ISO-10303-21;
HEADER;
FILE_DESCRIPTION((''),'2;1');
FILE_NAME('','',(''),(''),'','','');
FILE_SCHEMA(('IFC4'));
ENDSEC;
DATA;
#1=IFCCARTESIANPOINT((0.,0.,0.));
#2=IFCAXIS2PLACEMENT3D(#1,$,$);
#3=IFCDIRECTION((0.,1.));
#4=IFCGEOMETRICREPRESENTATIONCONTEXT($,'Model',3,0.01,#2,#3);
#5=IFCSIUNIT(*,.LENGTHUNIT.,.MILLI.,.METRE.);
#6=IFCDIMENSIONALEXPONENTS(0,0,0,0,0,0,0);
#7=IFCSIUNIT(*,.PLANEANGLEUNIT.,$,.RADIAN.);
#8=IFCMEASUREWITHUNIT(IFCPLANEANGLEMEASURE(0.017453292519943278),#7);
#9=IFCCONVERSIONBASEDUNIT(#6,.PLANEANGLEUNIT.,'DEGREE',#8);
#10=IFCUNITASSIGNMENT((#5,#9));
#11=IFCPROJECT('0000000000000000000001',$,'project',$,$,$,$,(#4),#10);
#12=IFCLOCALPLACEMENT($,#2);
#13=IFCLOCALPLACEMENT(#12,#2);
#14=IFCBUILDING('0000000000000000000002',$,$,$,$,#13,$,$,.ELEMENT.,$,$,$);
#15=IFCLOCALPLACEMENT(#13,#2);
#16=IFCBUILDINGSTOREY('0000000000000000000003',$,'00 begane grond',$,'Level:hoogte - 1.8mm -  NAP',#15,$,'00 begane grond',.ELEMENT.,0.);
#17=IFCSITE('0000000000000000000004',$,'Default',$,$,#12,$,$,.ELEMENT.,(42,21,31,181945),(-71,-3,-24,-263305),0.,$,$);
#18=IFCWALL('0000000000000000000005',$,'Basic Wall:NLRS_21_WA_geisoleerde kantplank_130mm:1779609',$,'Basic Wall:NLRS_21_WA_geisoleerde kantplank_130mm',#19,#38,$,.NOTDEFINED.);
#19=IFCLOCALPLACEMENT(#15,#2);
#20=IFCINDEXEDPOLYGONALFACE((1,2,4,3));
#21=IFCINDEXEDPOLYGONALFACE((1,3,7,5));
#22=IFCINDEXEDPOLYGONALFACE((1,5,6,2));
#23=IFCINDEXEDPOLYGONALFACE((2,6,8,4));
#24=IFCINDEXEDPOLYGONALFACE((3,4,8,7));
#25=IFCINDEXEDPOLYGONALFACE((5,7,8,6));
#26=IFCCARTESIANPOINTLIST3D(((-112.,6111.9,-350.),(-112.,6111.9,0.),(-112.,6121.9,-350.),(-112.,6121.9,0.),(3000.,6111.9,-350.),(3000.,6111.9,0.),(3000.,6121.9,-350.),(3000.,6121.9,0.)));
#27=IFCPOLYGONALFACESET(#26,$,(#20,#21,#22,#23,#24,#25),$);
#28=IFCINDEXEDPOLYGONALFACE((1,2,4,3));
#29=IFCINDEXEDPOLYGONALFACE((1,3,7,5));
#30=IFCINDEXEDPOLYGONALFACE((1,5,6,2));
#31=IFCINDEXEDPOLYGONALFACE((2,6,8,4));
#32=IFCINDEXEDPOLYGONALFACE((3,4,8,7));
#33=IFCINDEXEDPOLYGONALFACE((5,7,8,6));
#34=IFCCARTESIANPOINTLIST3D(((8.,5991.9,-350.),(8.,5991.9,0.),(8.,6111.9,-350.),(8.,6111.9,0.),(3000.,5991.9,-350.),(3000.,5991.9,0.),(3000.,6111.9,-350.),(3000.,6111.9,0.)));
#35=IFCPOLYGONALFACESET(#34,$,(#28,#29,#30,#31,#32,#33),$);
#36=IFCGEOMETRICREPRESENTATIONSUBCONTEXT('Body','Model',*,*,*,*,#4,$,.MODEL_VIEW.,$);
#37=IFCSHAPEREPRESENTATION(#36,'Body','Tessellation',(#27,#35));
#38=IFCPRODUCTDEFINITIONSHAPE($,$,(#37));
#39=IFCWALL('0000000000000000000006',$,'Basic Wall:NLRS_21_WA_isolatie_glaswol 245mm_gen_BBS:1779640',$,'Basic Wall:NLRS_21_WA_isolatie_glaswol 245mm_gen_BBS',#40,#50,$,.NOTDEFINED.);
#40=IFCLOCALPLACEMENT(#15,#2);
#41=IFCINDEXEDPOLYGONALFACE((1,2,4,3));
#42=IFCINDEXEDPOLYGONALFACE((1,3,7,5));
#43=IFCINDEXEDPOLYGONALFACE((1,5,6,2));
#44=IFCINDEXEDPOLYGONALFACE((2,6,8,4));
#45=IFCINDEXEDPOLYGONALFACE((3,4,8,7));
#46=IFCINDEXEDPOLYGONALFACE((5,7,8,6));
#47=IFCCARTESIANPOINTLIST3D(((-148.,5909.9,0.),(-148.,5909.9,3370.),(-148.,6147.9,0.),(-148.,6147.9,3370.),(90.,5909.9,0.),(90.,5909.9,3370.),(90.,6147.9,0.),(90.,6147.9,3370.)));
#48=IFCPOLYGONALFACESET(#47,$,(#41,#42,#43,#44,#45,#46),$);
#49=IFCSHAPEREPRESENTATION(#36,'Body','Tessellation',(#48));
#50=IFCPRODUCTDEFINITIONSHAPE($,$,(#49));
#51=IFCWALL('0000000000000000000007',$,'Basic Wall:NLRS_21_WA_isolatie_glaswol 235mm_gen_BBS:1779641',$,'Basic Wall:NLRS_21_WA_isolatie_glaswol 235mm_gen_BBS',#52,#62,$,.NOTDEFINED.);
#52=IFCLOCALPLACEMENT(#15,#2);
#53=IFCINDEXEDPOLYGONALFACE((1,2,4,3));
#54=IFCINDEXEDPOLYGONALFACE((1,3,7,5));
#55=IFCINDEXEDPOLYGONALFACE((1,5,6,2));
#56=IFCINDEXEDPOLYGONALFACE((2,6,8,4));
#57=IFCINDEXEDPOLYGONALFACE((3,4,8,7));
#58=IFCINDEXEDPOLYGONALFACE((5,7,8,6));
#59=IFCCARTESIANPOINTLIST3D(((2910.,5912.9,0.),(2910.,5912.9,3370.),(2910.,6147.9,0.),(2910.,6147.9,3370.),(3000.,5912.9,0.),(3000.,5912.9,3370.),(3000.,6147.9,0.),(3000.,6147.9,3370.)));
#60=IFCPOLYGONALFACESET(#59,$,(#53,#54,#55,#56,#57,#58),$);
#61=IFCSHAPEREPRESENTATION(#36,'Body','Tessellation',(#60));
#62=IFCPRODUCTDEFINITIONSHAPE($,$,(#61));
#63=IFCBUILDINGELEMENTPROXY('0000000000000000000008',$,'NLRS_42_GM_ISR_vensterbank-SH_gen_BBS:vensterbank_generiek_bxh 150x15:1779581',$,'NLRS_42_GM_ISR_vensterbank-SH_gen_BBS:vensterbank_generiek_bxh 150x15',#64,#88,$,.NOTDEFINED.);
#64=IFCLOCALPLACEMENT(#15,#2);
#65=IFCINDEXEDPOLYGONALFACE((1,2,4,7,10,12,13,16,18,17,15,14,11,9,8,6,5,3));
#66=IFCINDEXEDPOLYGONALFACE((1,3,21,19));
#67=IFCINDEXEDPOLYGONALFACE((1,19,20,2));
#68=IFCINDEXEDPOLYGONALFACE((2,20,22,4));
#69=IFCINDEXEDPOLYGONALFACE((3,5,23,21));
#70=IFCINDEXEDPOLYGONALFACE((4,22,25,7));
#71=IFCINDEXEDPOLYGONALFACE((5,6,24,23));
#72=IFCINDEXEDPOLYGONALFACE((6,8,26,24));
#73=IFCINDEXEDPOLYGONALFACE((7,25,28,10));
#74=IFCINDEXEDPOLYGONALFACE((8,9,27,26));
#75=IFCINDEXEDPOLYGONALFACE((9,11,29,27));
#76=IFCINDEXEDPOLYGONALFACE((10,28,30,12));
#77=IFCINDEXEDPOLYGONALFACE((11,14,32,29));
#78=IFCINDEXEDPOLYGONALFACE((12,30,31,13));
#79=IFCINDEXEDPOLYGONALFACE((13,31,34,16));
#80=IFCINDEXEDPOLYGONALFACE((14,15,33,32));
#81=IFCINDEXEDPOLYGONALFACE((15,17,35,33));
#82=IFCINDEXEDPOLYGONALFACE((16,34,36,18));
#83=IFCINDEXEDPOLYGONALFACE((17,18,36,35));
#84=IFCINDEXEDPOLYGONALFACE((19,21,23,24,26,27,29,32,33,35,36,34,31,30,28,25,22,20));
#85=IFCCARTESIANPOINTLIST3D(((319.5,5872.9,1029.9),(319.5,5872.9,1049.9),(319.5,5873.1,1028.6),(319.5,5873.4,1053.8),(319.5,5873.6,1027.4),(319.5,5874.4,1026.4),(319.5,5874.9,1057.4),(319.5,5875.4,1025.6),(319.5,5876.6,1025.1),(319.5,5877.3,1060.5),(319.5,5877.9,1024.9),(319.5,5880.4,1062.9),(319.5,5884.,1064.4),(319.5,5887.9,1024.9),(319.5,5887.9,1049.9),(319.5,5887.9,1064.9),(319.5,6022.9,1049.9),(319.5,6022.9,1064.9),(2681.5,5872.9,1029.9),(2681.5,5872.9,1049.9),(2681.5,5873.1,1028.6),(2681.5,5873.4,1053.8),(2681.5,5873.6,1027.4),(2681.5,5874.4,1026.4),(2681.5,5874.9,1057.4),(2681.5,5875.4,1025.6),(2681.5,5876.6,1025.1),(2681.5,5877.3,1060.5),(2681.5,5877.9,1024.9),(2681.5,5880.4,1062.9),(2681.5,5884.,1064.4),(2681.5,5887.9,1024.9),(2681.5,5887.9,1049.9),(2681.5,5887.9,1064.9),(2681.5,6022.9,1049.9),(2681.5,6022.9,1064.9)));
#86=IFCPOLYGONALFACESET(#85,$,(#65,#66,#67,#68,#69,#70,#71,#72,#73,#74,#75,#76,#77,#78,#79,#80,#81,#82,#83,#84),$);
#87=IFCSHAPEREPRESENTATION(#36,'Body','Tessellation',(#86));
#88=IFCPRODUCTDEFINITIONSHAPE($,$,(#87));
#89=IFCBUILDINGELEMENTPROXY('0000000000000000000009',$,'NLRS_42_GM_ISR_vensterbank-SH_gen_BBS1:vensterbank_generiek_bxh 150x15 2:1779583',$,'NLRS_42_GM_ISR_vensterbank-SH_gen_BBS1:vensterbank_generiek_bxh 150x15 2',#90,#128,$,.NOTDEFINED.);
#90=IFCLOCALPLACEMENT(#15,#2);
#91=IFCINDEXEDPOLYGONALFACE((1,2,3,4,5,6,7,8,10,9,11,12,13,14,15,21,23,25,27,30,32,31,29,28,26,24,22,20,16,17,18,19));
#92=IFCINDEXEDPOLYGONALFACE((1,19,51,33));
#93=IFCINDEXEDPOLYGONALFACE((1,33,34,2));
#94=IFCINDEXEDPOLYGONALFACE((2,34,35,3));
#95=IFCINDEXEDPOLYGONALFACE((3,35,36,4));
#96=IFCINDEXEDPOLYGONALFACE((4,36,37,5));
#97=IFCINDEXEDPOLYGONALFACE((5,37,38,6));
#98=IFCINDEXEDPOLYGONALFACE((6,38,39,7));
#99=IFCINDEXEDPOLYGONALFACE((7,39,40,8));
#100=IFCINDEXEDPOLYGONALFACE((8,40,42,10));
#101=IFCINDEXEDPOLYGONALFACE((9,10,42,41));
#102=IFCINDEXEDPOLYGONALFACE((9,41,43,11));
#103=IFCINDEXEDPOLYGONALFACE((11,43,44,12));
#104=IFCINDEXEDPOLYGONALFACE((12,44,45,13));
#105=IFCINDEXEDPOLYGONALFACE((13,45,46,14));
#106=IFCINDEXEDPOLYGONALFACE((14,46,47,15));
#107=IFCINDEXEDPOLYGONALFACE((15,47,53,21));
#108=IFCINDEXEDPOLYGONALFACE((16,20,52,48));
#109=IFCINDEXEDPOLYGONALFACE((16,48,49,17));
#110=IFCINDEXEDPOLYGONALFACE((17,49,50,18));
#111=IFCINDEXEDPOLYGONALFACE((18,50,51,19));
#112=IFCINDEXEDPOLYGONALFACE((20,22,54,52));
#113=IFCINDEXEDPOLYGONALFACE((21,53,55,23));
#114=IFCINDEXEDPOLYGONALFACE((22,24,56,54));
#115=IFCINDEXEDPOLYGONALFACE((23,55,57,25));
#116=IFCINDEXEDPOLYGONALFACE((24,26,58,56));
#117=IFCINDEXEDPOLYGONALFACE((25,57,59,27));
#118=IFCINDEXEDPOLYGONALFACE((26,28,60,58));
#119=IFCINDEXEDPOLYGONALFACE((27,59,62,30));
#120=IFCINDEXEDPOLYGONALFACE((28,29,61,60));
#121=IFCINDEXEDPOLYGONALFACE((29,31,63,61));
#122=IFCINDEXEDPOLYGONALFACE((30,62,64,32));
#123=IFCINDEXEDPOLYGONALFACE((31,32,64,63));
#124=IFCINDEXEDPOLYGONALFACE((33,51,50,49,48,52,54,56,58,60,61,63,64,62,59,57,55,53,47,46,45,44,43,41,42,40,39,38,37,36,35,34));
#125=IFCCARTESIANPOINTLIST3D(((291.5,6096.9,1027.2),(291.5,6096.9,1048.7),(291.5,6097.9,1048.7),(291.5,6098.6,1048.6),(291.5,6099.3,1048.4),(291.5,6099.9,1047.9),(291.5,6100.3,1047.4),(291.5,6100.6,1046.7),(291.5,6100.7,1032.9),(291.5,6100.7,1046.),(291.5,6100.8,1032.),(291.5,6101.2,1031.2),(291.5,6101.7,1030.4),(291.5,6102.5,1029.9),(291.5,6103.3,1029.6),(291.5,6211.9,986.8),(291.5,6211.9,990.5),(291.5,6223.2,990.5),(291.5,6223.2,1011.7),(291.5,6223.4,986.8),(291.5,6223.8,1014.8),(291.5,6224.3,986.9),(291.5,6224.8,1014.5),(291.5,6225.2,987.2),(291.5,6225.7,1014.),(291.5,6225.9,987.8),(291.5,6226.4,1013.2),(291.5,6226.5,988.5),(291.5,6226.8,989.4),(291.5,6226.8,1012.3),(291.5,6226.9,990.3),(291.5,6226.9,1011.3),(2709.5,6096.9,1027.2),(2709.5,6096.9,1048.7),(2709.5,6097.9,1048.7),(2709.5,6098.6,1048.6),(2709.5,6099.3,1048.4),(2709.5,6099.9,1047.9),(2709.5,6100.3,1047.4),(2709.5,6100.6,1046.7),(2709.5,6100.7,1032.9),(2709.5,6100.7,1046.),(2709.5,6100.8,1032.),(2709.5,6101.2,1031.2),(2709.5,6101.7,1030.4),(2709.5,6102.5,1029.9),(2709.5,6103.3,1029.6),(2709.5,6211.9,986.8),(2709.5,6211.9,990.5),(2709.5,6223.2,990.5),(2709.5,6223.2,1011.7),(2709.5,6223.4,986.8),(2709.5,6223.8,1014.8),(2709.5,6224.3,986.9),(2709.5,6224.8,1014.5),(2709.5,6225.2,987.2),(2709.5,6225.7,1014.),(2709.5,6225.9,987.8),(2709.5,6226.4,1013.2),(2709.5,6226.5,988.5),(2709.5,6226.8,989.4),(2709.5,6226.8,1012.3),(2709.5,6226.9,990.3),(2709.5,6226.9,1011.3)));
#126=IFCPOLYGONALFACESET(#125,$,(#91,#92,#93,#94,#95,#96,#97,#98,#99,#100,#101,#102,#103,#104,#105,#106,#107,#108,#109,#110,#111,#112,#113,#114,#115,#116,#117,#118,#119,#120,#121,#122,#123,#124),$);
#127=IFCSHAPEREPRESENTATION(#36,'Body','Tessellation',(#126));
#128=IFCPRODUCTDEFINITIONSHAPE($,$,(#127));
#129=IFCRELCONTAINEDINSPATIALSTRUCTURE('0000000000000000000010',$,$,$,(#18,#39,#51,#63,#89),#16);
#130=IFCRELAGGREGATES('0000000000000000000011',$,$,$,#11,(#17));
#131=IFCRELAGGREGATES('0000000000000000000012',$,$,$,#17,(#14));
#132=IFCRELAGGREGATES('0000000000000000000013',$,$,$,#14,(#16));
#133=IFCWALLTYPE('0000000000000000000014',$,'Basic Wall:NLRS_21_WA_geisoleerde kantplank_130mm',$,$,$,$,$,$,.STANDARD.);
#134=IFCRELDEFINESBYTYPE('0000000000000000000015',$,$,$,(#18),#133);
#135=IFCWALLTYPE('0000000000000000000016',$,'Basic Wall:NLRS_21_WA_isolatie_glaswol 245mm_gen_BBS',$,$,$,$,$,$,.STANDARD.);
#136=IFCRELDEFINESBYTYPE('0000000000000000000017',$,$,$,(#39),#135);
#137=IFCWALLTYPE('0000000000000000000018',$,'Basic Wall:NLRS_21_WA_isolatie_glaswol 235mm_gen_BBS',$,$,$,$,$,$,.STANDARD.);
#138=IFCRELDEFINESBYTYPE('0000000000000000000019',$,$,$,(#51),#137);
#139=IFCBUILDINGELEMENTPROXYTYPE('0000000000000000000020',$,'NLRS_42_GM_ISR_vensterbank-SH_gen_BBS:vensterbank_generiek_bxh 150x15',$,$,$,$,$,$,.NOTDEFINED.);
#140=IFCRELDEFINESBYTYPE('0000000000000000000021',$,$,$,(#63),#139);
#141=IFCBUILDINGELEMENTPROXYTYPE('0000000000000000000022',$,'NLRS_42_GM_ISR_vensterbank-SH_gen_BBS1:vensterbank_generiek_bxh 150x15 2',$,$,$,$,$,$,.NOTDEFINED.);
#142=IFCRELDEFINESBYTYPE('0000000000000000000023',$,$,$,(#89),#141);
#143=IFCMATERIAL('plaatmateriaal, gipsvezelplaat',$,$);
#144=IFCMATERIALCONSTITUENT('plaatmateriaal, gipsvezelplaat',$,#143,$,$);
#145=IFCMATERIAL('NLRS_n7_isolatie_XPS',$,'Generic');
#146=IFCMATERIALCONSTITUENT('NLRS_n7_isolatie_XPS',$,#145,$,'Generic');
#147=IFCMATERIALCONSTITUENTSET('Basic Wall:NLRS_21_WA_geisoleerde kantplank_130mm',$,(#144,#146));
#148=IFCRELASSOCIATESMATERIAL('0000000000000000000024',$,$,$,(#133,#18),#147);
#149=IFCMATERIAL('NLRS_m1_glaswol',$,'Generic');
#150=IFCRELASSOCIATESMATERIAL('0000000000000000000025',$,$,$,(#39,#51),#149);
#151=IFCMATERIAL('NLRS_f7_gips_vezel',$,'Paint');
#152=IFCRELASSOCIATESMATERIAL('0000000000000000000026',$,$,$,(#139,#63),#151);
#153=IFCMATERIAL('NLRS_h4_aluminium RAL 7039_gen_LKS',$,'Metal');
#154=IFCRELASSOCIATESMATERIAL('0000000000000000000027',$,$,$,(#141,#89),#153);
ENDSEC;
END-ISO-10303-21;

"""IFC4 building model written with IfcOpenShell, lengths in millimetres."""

from ifc_helpers import new_model, entity, si_unit, converted_unit, direction, frame, origin, place, context, subcontext, project, spatial, line, arc, indexed_curve, outline, extrude, source, transform, mapped, material, constituent, constituent_set, type_object, type_shapes, element, save


model = new_model("IFC4")

# Units and contexts
model_context = context("Model", 3, precision=0.01, world=origin(), true_north=direction((0.0, 1.0)))
body_context = subcontext(model_context, "Body", "Model", "MODEL_VIEW")
ifc_project = project(units=[si_unit("LENGTHUNIT", "METRE", prefix="MILLI"), converted_unit("PLANEANGLEUNIT", "DEGREE", entity("IfcPlaneAngleMeasure", 0.017453292519943278), si_unit("PLANEANGLEUNIT", "RADIAN"), dimensions=[0, 0, 0, 0, 0, 0, 0])], contexts=[model_context])

# Site, building, storey
site_placement = place(None, origin())
site = spatial("IfcSite", under=ifc_project, at=site_placement, Name="Default", CompositionType="ELEMENT", RefLatitude=(42, 21, 31, 181945), RefLongitude=(-71, -3, -24, -263305), RefElevation=0.0)
building_placement = place(site_placement, origin())
building = spatial("IfcBuilding", under=site, at=building_placement, CompositionType="ELEMENT")
storey_placement = place(building_placement, origin())
storey = spatial("IfcBuildingStorey", under=building, at=storey_placement, Name="00 begane grond", ObjectType="Level:hoogte - 1.8mm -  NAP", LongName="00 begane grond", CompositionType="ELEMENT", Elevation=0.0)

# Shared definitions
ifc_material_1 = material(Name="NLRS_f7_gips_vezel", Category="Paint")

# Shared definitions
ifc_material_2 = material(Name="NLRS_h4_aluminium RAL 7039_gen_LKS", Category="Metal")

# Walls
ifc_material_3 = material(Name="plaatmateriaal, gipsvezelplaat")
ifc_constituent_1 = constituent(ifc_material_3, Name="plaatmateriaal, gipsvezelplaat")
ifc_material_4 = material(Name="NLRS_n7_isolatie_XPS", Category="Generic")
ifc_constituent_2 = constituent(ifc_material_4, Name="NLRS_n7_isolatie_XPS", Category="Generic")
ifc_constituent_set_1 = constituent_set(constituents=[ifc_constituent_1, ifc_constituent_2], Name="Basic Wall:NLRS_21_WA_geisoleerde kantplank_130mm")
wall_type_1 = type_object("IfcWallType", Name="Basic Wall:NLRS_21_WA_geisoleerde kantplank_130mm", PredefinedType="STANDARD", material=ifc_constituent_set_1)
wall_1_placement = place(storey_placement, frame((8.0, 6056.9, -350.0)))
element("IfcWall", 1, at=wall_1_placement, inside=storey, type_object=wall_type_1, material=ifc_constituent_set_1, Name="Basic Wall:NLRS_21_WA_geisoleerde kantplank_130mm:1779609", ObjectType="Basic Wall:NLRS_21_WA_geisoleerde kantplank_130mm", PredefinedType="NOTDEFINED", context=body_context, shape_type="SweptSolid", body=[
    extrude(outline(indexed_curve([(-5.0, -1556.0), (5.0, -1556.0), (5.0, 1556.0), (-5.0, 1556.0), (-5.0, -1556.0)], self_intersect=False)), frame((1436.0, 60.0, 0.0), z_axis=(0.0, 0.0, 1.0), x_axis=(0.0, -1.0, 0.0)), (0.0, 0.0, 1.0), 350.0),
    extrude(outline(indexed_curve([(-60.0, -1496.0), (60.0, -1496.0), (60.0, 1496.0), (-60.0, 1496.0), (-60.0, -1496.0)], self_intersect=False)), frame((1496.0, -5.0, 0.0), z_axis=(0.0, 0.0, 1.0), x_axis=(0.0, 1.0, 0.0)), (0.0, 0.0, 1.0), 350.0),
])
ifc_material_5 = material(Name="NLRS_m1_glaswol", Category="Generic")
wall_type_2 = type_object("IfcWallType", Name="Basic Wall:NLRS_21_WA_isolatie_glaswol 245mm_gen_BBS", PredefinedType="STANDARD")
wall_2_placement = place(storey_placement, frame((-29.0, 6147.9, 0.0), z_axis=(0.0, 0.0, 1.0), x_axis=(0.0, -1.0, 0.0)))
element("IfcWall", 2, at=wall_2_placement, inside=storey, type_object=wall_type_2, material=ifc_material_5, Name="Basic Wall:NLRS_21_WA_isolatie_glaswol 245mm_gen_BBS:1779640", ObjectType="Basic Wall:NLRS_21_WA_isolatie_glaswol 245mm_gen_BBS", PredefinedType="NOTDEFINED", context=body_context, shape_type="SweptSolid", body=[
    extrude(outline(indexed_curve([(238.0, 119.0), (0.0, 119.0), (0.0, -119.0), (238.0, -119.0), (238.0, 119.0)], self_intersect=False)), origin(), (0.0, 0.0, 1.0), 3370.0),
])
wall_type_3 = type_object("IfcWallType", Name="Basic Wall:NLRS_21_WA_isolatie_glaswol 235mm_gen_BBS", PredefinedType="STANDARD")
wall_3_placement = place(storey_placement, frame((2910.0, 6030.4, 0.0)))
element("IfcWall", 3, at=wall_3_placement, inside=storey, type_object=wall_type_3, material=ifc_material_5, Name="Basic Wall:NLRS_21_WA_isolatie_glaswol 235mm_gen_BBS:1779641", ObjectType="Basic Wall:NLRS_21_WA_isolatie_glaswol 235mm_gen_BBS", PredefinedType="NOTDEFINED", context=body_context, shape_type="SweptSolid", body=[
    extrude(outline(indexed_curve([(90.0, 117.5), (0.0, 117.5), (0.0, -117.5), (90.0, -117.5), (90.0, 117.5)], self_intersect=False)), origin(), (0.0, 0.0, 1.0), 3370.0),
])

# Building element proxies
building_element_proxy_type_1 = type_object("IfcBuildingElementProxyType", Name="NLRS_42_GM_ISR_vensterbank-SH_gen_BBS:vensterbank_generiek_bxh 150x15", PredefinedType="NOTDEFINED", material=ifc_material_1)
shared_shape_1 = source(origin(), body_context, "Body", "SweptSolid", [
    extrude(outline(indexed_curve([(-28.7, -20.0), (106.2, -20.0), (106.2, -5.0), (-28.8, -5.0), (-28.8, 20.0), (-38.7, 20.0), (-42.3, 18.5), (-43.8, 15.0), (-43.7, -5.0), (-39.4, -15.6)], segments=[line(1, 2, 3, 4, 5, 6), arc(6, 7, 8), line(8, 9), arc(9, 10, 1)], self_intersect=False)), frame((-1181.0, 106.2, -5.0), z_axis=(1.0, 0.0, 0.0), x_axis=(0.0, -1.0, 0.0)), (0.0, 0.0, 1.0), 2362.0),
])
type_shapes(building_element_proxy_type_1, [shared_shape_1])
proxy_1_placement = place(storey_placement, frame((1500.5, 6022.9, 1049.9), z_axis=(0.0, 0.0, 1.0), x_axis=(-1.0, 0.0, 0.0)))
element("IfcBuildingElementProxy", 4, at=proxy_1_placement, inside=storey, type_object=building_element_proxy_type_1, material=ifc_material_1, Name="NLRS_42_GM_ISR_vensterbank-SH_gen_BBS:vensterbank_generiek_bxh 150x15:1779581", ObjectType="NLRS_42_GM_ISR_vensterbank-SH_gen_BBS:vensterbank_generiek_bxh 150x15", PredefinedType="NOTDEFINED", context=body_context, shape_type="MappedRepresentation", body=[
    mapped(shared_shape_1, transform((0.0, 0.0, 0.0), scale=1.0)),
])
building_element_proxy_type_2 = type_object("IfcBuildingElementProxyType", Name="NLRS_42_GM_ISR_vensterbank-SH_gen_BBS1:vensterbank_generiek_bxh 150x15 2", PredefinedType="NOTDEFINED", material=ifc_material_2)
shared_shape_2 = source(origin(), body_context, "Body", "SweptSolid", [
    extrude(outline(indexed_curve([(3.7, -54.0), (-11.8, 72.2), (-33.3, 72.2), (-33.3, 71.2), (-32.5, 69.3), (-30.6, 68.5), (-17.5, 68.5), (-15.4, 67.7), (-14.2, 65.8), (0.6, -54.7), (1.8, -56.9), (4.1, -57.8), (25.1, -57.8), (27.6, -56.8), (28.6, -54.3), (28.6, -42.8), (24.9, -42.8), (24.9, -54.0)], segments=[line(1, 2, 3, 4), arc(4, 5, 6), line(6, 7), arc(7, 8, 9), line(9, 10), arc(10, 11, 12), line(12, 13), arc(13, 14, 15), line(15, 16, 17, 18, 1)], self_intersect=False)), frame((-1209.0, 72.2, 19.1), z_axis=(-1.0, 0.0, 0.0), x_axis=(0.0, 0.0, -1.0)), (0.0, 0.0, -1.0), 2418.0),
])
type_shapes(building_element_proxy_type_2, [shared_shape_2])
proxy_2_placement = place(storey_placement, frame((1500.5, 6096.9, 996.3)))
element("IfcBuildingElementProxy", 5, at=proxy_2_placement, inside=storey, type_object=building_element_proxy_type_2, material=ifc_material_2, Name="NLRS_42_GM_ISR_vensterbank-SH_gen_BBS1:vensterbank_generiek_bxh 150x15 2:1779583", ObjectType="NLRS_42_GM_ISR_vensterbank-SH_gen_BBS1:vensterbank_generiek_bxh 150x15 2", PredefinedType="NOTDEFINED", context=body_context, shape_type="MappedRepresentation", body=[
    mapped(shared_shape_2, transform((0.0, 0.0, 0.0), scale=1.0)),
])

save(model, "model.ifc")
